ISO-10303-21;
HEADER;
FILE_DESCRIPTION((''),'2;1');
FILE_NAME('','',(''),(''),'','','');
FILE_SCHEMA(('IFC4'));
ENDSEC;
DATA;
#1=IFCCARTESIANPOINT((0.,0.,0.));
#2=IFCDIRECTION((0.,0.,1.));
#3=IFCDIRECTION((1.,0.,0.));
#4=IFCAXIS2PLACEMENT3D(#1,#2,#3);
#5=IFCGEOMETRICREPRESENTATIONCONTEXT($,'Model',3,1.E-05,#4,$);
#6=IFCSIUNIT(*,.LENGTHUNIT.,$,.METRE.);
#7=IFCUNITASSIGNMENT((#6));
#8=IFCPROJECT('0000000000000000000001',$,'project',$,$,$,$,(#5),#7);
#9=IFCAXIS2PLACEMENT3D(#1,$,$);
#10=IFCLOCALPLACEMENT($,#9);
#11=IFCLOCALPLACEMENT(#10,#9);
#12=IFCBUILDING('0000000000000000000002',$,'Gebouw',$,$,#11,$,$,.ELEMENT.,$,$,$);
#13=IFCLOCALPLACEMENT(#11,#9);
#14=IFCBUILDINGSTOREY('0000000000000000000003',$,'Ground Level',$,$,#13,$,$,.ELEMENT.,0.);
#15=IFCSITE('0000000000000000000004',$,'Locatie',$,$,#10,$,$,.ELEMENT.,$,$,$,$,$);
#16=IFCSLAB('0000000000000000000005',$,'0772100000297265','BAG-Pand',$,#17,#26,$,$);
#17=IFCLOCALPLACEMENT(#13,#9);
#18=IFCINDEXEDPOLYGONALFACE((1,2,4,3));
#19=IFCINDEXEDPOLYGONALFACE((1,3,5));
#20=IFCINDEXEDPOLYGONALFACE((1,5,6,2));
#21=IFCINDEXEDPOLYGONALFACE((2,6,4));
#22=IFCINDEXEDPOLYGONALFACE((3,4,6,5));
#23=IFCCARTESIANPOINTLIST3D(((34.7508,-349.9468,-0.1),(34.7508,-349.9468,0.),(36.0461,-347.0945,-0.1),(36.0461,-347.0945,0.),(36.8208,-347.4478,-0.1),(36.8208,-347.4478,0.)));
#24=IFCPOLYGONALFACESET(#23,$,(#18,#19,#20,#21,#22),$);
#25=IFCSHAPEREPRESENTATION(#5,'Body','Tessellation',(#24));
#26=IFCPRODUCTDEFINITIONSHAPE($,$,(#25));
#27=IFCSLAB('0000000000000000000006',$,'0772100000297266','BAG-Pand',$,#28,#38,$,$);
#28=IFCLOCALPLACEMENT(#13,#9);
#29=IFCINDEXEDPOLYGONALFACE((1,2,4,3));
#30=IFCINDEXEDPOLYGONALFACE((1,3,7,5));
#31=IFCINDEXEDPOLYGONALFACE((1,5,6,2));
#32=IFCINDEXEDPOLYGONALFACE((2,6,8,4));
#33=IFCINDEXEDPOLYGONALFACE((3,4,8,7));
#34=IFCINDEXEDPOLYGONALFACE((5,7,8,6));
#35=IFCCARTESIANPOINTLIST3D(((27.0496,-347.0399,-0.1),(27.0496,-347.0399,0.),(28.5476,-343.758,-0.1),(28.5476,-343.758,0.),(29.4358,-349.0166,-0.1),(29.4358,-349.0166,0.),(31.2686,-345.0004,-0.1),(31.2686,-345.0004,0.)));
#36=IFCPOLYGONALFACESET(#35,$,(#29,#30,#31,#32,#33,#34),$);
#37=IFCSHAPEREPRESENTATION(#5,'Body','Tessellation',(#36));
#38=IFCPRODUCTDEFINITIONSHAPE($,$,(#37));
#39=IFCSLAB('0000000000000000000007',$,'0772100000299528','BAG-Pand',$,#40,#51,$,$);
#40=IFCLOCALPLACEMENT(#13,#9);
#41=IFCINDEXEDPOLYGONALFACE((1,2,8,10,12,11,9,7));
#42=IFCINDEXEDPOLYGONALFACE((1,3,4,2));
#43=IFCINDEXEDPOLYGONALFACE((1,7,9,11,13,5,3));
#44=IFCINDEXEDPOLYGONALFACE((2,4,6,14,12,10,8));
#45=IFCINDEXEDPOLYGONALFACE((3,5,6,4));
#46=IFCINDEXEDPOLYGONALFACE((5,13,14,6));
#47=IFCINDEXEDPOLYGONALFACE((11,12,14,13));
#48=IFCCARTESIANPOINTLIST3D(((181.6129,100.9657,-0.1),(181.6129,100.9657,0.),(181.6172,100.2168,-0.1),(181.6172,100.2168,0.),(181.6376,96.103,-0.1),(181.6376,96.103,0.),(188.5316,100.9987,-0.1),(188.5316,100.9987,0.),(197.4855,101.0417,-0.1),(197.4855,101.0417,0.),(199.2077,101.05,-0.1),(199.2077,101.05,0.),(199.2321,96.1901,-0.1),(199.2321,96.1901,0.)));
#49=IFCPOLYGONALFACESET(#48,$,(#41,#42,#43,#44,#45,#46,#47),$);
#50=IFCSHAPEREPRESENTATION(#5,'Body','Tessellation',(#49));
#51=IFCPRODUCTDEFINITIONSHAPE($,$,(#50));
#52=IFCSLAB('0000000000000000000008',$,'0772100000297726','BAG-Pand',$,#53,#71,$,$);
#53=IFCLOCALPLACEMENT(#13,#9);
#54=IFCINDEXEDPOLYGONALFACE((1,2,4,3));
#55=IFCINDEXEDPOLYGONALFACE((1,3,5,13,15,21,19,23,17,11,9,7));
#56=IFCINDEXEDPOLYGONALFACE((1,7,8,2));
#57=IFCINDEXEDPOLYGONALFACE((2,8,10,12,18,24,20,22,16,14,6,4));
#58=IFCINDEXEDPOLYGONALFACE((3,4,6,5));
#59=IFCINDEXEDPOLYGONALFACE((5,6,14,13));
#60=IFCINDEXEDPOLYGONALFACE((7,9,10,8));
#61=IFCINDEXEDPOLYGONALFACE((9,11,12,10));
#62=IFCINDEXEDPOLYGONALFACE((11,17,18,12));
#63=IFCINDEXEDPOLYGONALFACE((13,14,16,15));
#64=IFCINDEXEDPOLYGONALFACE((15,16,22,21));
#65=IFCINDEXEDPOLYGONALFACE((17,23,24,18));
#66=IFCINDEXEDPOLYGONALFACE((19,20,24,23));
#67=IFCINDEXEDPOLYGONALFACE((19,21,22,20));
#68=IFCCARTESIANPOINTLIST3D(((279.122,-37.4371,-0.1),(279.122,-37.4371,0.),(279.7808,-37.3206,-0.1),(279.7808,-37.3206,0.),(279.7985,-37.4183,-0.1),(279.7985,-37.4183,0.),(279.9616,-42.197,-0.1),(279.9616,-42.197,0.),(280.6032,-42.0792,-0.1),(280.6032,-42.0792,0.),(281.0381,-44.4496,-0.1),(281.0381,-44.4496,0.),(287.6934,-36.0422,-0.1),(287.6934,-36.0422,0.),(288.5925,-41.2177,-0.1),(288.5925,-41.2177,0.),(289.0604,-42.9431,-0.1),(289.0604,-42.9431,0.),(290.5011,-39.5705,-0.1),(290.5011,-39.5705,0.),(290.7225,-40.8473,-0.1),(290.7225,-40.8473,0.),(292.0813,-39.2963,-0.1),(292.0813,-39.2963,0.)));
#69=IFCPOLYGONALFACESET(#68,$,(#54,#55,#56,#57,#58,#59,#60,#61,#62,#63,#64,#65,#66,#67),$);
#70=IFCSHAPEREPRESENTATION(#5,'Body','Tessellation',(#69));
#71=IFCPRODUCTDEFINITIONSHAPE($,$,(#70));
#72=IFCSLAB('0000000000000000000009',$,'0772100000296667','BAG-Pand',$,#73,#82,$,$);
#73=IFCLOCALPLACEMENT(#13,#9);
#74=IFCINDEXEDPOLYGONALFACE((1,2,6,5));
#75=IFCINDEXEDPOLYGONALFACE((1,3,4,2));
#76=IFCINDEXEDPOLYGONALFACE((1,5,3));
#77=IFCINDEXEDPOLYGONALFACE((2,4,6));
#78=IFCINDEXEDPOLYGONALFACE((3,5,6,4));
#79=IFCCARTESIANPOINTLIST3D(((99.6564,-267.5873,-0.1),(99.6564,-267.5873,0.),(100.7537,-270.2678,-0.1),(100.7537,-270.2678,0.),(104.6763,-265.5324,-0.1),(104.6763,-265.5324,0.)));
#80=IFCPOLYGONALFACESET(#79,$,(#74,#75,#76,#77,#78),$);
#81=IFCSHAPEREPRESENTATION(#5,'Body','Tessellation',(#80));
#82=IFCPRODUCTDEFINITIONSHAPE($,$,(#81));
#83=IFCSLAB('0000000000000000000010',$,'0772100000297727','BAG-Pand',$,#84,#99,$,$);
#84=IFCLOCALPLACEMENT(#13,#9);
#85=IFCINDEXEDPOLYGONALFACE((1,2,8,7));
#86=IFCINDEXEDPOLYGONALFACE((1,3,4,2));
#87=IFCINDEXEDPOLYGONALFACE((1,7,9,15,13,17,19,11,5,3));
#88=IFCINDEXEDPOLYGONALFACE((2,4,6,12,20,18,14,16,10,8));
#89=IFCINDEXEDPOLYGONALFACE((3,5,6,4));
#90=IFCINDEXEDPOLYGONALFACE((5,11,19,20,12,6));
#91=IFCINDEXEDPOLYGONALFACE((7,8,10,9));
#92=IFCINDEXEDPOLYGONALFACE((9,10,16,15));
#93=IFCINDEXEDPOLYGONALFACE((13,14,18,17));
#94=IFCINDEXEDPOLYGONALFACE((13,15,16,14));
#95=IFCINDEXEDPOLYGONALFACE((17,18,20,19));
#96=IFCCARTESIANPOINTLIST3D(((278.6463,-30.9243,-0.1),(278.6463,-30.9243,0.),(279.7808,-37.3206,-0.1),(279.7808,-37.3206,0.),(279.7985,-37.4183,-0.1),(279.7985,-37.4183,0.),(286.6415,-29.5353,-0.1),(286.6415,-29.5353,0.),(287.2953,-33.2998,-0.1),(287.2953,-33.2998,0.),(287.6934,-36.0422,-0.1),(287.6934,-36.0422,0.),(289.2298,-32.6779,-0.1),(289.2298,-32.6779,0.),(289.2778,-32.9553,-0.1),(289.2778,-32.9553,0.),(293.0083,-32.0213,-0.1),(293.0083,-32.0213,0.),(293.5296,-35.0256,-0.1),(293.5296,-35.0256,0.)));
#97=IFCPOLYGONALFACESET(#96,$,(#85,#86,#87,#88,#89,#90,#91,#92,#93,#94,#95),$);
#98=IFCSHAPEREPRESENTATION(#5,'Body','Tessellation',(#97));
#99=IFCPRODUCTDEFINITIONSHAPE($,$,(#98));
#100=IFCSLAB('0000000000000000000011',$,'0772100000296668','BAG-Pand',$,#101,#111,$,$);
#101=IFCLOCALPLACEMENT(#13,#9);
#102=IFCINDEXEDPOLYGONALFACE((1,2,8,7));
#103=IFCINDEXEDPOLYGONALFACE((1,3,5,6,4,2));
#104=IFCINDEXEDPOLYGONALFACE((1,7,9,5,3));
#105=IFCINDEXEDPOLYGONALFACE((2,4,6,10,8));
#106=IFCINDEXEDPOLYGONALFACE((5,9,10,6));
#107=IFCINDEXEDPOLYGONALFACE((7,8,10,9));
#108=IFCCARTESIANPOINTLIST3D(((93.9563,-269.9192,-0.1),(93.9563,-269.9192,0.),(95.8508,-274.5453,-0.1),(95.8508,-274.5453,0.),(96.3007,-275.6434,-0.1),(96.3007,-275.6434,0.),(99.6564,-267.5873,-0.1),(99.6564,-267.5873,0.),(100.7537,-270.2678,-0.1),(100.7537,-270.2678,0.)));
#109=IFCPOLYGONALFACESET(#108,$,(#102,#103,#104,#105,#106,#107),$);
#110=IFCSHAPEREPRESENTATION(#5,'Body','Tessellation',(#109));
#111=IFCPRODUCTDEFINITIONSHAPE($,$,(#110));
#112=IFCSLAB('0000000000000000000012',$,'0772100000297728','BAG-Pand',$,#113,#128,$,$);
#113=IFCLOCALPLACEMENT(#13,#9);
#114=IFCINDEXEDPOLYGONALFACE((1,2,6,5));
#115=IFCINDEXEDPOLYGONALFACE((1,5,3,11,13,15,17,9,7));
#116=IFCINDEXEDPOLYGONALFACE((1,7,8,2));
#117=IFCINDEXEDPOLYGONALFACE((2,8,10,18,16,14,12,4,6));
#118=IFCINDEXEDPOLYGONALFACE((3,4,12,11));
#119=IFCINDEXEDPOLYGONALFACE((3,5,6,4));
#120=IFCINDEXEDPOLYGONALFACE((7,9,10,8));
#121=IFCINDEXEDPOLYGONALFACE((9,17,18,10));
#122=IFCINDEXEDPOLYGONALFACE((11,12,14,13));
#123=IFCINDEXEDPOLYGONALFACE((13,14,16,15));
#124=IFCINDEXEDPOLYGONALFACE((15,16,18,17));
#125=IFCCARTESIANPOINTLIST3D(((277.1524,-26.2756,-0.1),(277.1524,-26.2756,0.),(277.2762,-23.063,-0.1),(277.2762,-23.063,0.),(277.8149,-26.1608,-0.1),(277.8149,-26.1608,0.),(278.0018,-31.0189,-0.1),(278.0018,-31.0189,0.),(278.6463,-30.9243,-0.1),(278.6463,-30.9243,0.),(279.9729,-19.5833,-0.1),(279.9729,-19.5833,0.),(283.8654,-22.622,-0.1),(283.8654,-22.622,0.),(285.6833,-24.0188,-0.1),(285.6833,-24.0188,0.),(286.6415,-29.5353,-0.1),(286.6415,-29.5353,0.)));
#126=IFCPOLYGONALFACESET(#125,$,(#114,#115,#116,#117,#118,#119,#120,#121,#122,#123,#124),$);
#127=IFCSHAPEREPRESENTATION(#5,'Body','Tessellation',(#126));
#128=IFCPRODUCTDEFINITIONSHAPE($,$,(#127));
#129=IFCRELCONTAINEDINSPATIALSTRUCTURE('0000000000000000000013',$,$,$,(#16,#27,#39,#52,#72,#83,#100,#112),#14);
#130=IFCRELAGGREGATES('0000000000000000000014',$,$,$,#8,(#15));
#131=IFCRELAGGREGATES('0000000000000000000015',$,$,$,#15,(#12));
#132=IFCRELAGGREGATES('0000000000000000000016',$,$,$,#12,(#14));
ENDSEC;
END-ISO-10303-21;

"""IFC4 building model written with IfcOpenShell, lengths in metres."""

from ifc_helpers import new_model, si_unit, frame, origin, origin_with_axes, place, context, project, spatial, polyline, outline, extrude, element, save


model = new_model("IFC4")

# Units and contexts
model_context = context("Model", 3, precision=1e-05, world=origin_with_axes())
ifc_project = project(units=[si_unit("LENGTHUNIT", "METRE")], contexts=[model_context])

# Site, building, storey
site_placement = place(None, origin())
site = spatial("IfcSite", under=ifc_project, at=site_placement, Name="Locatie", CompositionType="ELEMENT")
building_placement = place(site_placement, origin())
building = spatial("IfcBuilding", under=site, at=building_placement, Name="Gebouw", CompositionType="ELEMENT")
storey_placement = place(building_placement, origin())
storey = spatial("IfcBuildingStorey", under=building, at=storey_placement, Name="Ground Level", CompositionType="ELEMENT", Elevation=0.0)

# Slabs
slab_1_placement = place(storey_placement, origin())
element("IfcSlab", 1, at=slab_1_placement, inside=storey, Name="0772100000297265", Description="BAG-Pand", context=model_context, shape_type="SweptSolid", body=[
    extrude(outline(polyline([(36.0461, -347.0945), (36.8208, -347.4478), (34.7508, -349.9468), (36.0461, -347.0945)])), frame((0.0, 0.0, -0.1), z_axis=(0.0, 0.0, 1.0), x_axis=(1.0, 0.0, 0.0)), (0.0, 0.0, 1.0), 0.1),
])
slab_2_placement = place(storey_placement, origin())
element("IfcSlab", 2, at=slab_2_placement, inside=storey, Name="0772100000297266", Description="BAG-Pand", context=model_context, shape_type="SweptSolid", body=[
    extrude(outline(polyline([(28.5476, -343.758), (31.2686, -345.0004), (29.4358, -349.0166), (27.0496, -347.0399), (28.5476, -343.758)])), frame((0.0, 0.0, -0.1), z_axis=(0.0, 0.0, 1.0), x_axis=(1.0, 0.0, 0.0)), (0.0, 0.0, 1.0), 0.1),
])
slab_3_placement = place(storey_placement, origin())
element("IfcSlab", 3, at=slab_3_placement, inside=storey, Name="0772100000299528", Description="BAG-Pand", context=model_context, shape_type="SweptSolid", body=[
    extrude(outline(polyline([(181.6172, 100.2168), (181.6129, 100.9657), (188.5316, 100.9987), (197.4855, 101.0417), (199.2077, 101.05), (199.2321, 96.1901), (181.6376, 96.103), (181.6172, 100.2168)])), frame((0.0, 0.0, -0.1), z_axis=(0.0, 0.0, 1.0), x_axis=(1.0, 0.0, 0.0)), (0.0, 0.0, 1.0), 0.1),
])
slab_4_placement = place(storey_placement, origin())
element("IfcSlab", 4, at=slab_4_placement, inside=storey, Name="0772100000297726", Description="BAG-Pand", context=model_context, shape_type="SweptSolid", body=[
    extrude(outline(polyline([(281.0381, -44.4496), (280.6032, -42.0792), (279.9616, -42.197), (279.122, -37.4371), (279.7808, -37.3206), (279.7985, -37.4183), (287.6934, -36.0422), (288.5925, -41.2177), (290.7225, -40.8473), (290.5011, -39.5705), (292.0813, -39.2963), (289.0604, -42.9431), (281.0381, -44.4496)])), frame((0.0, 0.0, -0.1), z_axis=(0.0, 0.0, 1.0), x_axis=(1.0, 0.0, 0.0)), (0.0, 0.0, 1.0), 0.1),
])
slab_5_placement = place(storey_placement, origin())
element("IfcSlab", 5, at=slab_5_placement, inside=storey, Name="0772100000296667", Description="BAG-Pand", context=model_context, shape_type="SweptSolid", body=[
    extrude(outline(polyline([(99.6564, -267.5873), (104.6763, -265.5324), (100.7537, -270.2678), (99.6564, -267.5873)])), frame((0.0, 0.0, -0.1), z_axis=(0.0, 0.0, 1.0), x_axis=(1.0, 0.0, 0.0)), (0.0, 0.0, 1.0), 0.1),
])
slab_6_placement = place(storey_placement, origin())
element("IfcSlab", 6, at=slab_6_placement, inside=storey, Name="0772100000297727", Description="BAG-Pand", context=model_context, shape_type="SweptSolid", body=[
    extrude(outline(polyline([(279.7808, -37.3206), (278.6463, -30.9243), (286.6415, -29.5353), (287.2953, -33.2998), (289.2778, -32.9553), (289.2298, -32.6779), (293.0083, -32.0213), (293.5296, -35.0256), (287.6934, -36.0422), (279.7985, -37.4183), (279.7808, -37.3206)])), frame((0.0, 0.0, -0.1), z_axis=(0.0, 0.0, 1.0), x_axis=(1.0, 0.0, 0.0)), (0.0, 0.0, 1.0), 0.1),
])
slab_7_placement = place(storey_placement, origin())
element("IfcSlab", 7, at=slab_7_placement, inside=storey, Name="0772100000296668", Description="BAG-Pand", context=model_context, shape_type="SweptSolid", body=[
    extrude(outline(polyline([(95.8508, -274.5453), (93.9563, -269.9192), (99.6564, -267.5873), (100.7537, -270.2678), (96.3007, -275.6434), (95.8508, -274.5453)])), frame((0.0, 0.0, -0.1), z_axis=(0.0, 0.0, 1.0), x_axis=(1.0, 0.0, 0.0)), (0.0, 0.0, 1.0), 0.1),
])
slab_8_placement = place(storey_placement, origin())
element("IfcSlab", 8, at=slab_8_placement, inside=storey, Name="0772100000297728", Description="BAG-Pand", context=model_context, shape_type="SweptSolid", body=[
    extrude(outline(polyline([(277.1524, -26.2756), (277.8149, -26.1608), (277.2762, -23.063), (279.9729, -19.5833), (283.8654, -22.622), (285.6833, -24.0188), (286.6415, -29.5353), (278.6463, -30.9243), (278.0018, -31.0189), (277.1524, -26.2756)])), frame((0.0, 0.0, -0.1), z_axis=(0.0, 0.0, 1.0), x_axis=(1.0, 0.0, 0.0)), (0.0, 0.0, 1.0), 0.1),
])

save(model, "model.ifc")
